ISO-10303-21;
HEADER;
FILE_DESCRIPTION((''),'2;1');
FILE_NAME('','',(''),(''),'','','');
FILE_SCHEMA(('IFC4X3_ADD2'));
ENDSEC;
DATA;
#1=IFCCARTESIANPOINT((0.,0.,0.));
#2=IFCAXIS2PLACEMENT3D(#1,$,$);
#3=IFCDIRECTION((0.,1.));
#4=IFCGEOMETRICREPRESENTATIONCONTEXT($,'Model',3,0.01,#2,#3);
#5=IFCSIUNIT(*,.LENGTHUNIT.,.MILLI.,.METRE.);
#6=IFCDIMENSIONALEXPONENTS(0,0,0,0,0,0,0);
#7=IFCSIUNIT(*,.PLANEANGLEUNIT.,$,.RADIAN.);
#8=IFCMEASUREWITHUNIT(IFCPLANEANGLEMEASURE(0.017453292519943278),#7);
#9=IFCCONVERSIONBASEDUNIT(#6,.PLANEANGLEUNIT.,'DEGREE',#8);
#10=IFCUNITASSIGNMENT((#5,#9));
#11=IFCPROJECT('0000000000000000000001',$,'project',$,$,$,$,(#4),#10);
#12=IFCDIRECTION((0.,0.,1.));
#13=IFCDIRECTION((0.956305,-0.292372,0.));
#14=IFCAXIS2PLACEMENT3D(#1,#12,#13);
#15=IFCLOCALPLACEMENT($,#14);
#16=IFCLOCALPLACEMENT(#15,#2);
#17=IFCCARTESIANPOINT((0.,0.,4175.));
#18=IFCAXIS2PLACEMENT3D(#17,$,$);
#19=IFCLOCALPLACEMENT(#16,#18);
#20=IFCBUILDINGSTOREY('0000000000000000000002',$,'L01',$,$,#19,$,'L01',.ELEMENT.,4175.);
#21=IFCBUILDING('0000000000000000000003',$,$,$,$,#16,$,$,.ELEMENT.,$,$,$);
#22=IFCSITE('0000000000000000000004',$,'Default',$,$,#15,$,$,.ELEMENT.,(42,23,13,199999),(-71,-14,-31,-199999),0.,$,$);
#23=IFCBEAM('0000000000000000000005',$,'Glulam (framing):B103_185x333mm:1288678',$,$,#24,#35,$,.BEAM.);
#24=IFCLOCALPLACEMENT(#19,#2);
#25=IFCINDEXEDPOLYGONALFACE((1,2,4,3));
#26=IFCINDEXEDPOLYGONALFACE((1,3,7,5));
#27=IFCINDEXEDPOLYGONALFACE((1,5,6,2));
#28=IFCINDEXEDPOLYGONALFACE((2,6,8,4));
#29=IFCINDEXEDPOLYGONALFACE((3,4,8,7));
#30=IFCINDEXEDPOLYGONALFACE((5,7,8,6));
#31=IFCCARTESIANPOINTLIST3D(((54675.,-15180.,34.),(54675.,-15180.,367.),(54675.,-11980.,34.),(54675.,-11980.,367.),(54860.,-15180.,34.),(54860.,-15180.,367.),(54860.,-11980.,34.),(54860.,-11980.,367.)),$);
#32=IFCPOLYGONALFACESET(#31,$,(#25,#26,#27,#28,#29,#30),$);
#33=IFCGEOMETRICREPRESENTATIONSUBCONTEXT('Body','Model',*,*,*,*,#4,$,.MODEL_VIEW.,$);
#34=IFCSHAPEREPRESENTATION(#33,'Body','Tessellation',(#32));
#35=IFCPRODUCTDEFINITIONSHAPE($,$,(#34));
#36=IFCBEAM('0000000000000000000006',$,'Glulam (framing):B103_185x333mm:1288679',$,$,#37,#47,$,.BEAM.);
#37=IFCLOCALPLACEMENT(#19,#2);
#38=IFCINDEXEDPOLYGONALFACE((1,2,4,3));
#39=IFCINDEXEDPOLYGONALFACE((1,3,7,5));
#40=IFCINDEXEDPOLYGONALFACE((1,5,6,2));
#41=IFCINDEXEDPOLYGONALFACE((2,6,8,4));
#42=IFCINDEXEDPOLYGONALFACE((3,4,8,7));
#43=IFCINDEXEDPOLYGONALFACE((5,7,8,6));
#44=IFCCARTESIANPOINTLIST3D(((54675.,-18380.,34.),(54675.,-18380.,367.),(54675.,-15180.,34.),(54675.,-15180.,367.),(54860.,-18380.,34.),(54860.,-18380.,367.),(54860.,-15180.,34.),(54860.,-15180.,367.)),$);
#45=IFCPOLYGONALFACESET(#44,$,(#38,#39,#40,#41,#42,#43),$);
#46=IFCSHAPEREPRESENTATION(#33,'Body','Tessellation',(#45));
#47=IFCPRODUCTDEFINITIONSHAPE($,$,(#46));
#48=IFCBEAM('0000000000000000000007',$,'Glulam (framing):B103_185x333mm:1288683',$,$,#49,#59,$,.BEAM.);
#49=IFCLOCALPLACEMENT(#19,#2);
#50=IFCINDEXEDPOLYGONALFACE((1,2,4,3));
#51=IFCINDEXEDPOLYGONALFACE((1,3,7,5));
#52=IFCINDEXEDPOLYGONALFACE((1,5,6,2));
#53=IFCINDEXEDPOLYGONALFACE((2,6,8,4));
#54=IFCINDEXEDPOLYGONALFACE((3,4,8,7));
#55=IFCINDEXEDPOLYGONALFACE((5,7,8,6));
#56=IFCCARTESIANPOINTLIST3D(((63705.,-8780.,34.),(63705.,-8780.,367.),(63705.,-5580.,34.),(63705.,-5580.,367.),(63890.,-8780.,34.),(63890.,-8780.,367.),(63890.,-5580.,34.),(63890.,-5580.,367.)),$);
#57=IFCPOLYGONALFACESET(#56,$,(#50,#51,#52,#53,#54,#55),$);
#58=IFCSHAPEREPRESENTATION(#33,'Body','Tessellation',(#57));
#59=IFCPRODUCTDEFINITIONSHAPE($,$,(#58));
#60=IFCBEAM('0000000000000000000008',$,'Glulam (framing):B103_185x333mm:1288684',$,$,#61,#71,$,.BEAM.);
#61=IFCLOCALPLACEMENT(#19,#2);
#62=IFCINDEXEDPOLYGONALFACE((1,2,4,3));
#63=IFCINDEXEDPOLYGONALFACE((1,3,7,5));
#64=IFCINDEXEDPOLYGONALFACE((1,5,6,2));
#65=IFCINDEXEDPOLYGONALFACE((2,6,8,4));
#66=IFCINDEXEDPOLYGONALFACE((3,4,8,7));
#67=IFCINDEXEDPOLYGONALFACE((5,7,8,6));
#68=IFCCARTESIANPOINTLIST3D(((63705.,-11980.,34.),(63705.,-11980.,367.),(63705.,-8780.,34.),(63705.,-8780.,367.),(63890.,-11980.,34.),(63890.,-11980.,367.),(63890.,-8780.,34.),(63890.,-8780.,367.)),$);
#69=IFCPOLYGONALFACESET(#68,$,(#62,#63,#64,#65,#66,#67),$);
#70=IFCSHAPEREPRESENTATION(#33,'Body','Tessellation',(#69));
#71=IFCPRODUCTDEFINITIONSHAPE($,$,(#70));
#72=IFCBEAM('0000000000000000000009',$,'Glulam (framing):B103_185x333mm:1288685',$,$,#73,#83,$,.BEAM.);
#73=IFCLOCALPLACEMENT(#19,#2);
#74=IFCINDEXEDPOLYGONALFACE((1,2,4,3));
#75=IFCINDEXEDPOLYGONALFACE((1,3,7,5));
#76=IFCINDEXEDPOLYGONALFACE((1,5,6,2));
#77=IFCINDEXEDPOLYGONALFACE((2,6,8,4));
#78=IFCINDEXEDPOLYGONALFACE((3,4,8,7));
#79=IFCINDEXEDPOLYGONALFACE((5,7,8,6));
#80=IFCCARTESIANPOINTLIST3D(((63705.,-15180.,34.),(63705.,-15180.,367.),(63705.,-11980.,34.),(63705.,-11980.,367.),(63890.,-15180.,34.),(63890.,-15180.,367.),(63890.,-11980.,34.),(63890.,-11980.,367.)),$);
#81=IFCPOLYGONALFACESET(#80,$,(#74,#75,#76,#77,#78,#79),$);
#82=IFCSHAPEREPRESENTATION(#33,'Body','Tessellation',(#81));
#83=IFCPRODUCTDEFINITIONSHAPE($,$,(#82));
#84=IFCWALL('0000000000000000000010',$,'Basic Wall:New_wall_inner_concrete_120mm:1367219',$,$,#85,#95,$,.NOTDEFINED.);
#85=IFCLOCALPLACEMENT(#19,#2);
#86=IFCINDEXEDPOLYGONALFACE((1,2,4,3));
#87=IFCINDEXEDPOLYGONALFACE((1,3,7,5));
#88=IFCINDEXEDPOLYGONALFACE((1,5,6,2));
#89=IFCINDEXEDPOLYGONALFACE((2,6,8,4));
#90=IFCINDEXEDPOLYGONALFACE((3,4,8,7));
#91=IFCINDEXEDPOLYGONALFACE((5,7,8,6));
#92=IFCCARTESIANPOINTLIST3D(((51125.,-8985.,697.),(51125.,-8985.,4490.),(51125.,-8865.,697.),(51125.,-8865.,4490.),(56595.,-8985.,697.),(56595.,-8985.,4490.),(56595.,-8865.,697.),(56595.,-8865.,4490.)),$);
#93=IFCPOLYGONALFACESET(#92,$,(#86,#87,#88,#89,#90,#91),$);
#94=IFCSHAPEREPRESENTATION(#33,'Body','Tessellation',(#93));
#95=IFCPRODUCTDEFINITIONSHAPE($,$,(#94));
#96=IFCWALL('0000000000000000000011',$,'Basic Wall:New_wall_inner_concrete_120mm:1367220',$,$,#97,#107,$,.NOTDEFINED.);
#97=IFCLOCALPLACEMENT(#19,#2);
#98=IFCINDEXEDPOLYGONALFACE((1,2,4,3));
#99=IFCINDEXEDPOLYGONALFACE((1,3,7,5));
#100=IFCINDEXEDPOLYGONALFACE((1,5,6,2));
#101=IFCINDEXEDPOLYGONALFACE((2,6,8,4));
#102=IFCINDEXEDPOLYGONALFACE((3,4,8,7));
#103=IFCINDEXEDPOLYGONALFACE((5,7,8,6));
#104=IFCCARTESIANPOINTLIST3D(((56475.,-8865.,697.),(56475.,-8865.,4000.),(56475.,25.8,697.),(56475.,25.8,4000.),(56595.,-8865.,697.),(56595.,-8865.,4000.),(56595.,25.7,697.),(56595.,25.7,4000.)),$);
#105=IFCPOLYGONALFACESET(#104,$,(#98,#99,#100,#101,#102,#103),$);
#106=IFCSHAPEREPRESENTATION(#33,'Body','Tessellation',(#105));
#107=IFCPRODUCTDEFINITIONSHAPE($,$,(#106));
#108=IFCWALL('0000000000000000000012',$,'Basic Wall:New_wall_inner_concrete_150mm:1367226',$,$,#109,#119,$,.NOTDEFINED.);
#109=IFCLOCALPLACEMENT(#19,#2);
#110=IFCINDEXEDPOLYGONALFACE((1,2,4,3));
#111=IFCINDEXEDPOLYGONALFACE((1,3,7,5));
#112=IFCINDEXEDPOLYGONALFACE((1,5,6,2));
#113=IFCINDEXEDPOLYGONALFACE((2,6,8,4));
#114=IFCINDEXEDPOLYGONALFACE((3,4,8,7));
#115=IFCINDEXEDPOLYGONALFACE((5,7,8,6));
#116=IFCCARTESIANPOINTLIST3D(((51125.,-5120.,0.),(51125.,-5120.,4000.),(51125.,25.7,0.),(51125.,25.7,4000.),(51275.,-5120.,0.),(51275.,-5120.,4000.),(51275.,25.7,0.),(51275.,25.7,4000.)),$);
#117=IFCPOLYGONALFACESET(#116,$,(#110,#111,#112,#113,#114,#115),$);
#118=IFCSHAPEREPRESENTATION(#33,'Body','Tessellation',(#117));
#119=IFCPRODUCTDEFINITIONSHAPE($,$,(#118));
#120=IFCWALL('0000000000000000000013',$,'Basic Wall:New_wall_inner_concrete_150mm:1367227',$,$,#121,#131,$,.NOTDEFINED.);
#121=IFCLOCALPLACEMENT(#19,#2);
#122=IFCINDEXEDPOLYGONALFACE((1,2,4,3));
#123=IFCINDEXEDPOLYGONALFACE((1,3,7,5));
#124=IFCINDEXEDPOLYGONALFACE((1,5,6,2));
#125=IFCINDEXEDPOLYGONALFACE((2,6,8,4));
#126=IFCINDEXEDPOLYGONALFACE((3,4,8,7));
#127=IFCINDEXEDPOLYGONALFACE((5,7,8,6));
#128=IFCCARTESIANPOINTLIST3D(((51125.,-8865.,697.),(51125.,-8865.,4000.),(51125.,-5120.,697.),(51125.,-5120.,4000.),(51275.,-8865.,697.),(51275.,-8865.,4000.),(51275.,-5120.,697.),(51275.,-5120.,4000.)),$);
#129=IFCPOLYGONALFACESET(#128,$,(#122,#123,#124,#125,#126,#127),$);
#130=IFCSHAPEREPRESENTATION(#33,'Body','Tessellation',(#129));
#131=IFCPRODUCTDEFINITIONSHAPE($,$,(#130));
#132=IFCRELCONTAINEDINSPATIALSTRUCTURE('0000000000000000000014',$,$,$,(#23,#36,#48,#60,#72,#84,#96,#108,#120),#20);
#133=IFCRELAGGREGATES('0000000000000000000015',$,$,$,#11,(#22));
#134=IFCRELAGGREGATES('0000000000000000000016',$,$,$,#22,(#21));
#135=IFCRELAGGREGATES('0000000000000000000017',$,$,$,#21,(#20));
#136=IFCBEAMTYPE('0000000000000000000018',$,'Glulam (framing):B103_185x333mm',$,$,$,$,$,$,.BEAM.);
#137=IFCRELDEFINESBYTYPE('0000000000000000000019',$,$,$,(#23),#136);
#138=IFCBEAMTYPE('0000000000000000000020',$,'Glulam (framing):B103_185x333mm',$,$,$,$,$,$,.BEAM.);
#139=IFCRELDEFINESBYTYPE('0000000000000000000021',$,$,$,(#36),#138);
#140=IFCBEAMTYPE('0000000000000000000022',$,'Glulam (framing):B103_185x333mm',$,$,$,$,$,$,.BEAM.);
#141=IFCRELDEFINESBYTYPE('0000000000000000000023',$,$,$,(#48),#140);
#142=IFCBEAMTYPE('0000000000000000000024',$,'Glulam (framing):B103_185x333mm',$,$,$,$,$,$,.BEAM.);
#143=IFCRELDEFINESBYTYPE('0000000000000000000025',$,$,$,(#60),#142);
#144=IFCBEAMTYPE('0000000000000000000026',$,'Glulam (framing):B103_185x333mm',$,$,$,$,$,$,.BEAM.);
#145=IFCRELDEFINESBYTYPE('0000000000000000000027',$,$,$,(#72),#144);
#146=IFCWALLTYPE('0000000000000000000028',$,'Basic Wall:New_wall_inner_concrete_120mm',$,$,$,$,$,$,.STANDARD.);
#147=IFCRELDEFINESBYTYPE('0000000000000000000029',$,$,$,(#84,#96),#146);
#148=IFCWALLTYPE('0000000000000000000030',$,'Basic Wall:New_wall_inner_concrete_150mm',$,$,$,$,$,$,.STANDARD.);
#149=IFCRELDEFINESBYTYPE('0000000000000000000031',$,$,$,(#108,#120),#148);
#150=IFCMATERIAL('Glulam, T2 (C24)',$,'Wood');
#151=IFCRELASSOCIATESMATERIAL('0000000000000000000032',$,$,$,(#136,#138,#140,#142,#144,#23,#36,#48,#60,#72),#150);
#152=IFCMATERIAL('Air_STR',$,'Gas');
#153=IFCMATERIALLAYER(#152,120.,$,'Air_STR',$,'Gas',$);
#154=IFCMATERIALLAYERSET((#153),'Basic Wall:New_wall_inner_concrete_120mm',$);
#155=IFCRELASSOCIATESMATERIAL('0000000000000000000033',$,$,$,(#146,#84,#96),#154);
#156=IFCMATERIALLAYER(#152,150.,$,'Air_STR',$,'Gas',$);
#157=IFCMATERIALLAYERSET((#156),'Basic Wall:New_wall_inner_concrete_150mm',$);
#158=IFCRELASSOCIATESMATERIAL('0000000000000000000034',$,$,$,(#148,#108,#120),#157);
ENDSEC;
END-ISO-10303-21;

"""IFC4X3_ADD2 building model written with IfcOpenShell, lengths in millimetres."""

from ifc_helpers import new_model, entity, si_unit, converted_unit, direction, frame, frame_2d, origin, origin_2d_with_axis, place, context, subcontext, project, spatial, rectangle, extrude, source, transform, mapped, material, layer, layer_set, material_profile, profile_set, profile_usage, type_object, type_shapes, element, save


model = new_model("IFC4X3_ADD2")

# Units and contexts
model_context = context("Model", 3, precision=0.01, world=origin(), true_north=direction((0.0, 1.0)))
body_context = subcontext(model_context, "Body", "Model", "MODEL_VIEW")
ifc_project = project(units=[si_unit("LENGTHUNIT", "METRE", prefix="MILLI"), converted_unit("PLANEANGLEUNIT", "DEGREE", entity("IfcPlaneAngleMeasure", 0.017453292519943278), si_unit("PLANEANGLEUNIT", "RADIAN"), dimensions=[0, 0, 0, 0, 0, 0, 0])], contexts=[model_context])

# Site, building, storey
site_placement = place(None, frame((0.0, 0.0, 0.0), z_axis=(0.0, 0.0, 1.0), x_axis=(0.956305, -0.292372, 0.0)))
site = spatial("IfcSite", under=ifc_project, at=site_placement, Name="Default", CompositionType="ELEMENT", RefLatitude=(42, 23, 13, 199999), RefLongitude=(-71, -14, -31, -199999), RefElevation=0.0)
building_placement = place(site_placement, origin())
building = spatial("IfcBuilding", under=site, at=building_placement, CompositionType="ELEMENT")
storey_placement = place(building_placement, frame((0.0, 0.0, 4175.0)))
storey = spatial("IfcBuildingStorey", under=building, at=storey_placement, Name="L01", LongName="L01", CompositionType="ELEMENT", Elevation=4175.0)

# Beams
ifc_material_1 = material(Name="Glulam, T2 (C24)", Category="Wood")
ifc_material_profile_1 = material_profile(ifc_material_1, rectangle(XDim=3200.0, YDim=185.0, at=origin_2d_with_axis()), Name="B103_185x333mm")
ifc_profile_set_1 = profile_set([ifc_material_profile_1], Name="B103_185x333mm")
ifc_profile_usage_1 = profile_usage(ifc_profile_set_1, cardinal=8)
beam_type_1 = type_object("IfcBeamType", Name="Glulam (framing):B103_185x333mm", PredefinedType="BEAM", material=ifc_profile_set_1)
shared_shape_1 = source(origin(), body_context, "Body", "SweptSolid", [
    extrude(rectangle(XDim=3200.0, YDim=185.0, at=origin_2d_with_axis()), frame((0.0, 0.0, -166.5), z_axis=(0.0, 0.0, 1.0), x_axis=(-1.0, 0.0, 0.0)), (0.0, 0.0, 1.0), 333.0),
])
type_shapes(beam_type_1, [shared_shape_1])
beam_1_placement = place(storey_placement, frame((54767.5, -13580.0, 200.5), z_axis=(0.0, 0.0, 1.0), x_axis=(0.0, -1.0, 0.0)))
element("IfcBeam", 1, at=beam_1_placement, inside=storey, type_object=beam_type_1, material=ifc_profile_usage_1, Name="Glulam (framing):B103_185x333mm:1288678", PredefinedType="BEAM", context=body_context, shape_type="MappedRepresentation", body=[
    mapped(shared_shape_1, transform((0.0, 0.0, 0.0), scale=1.0)),
])
beam_type_2 = type_object("IfcBeamType", Name="Glulam (framing):B103_185x333mm", PredefinedType="BEAM", material=ifc_profile_set_1)
shared_shape_2 = source(origin(), body_context, "Body", "SweptSolid", [
    extrude(rectangle(XDim=3200.0, YDim=185.0, at=origin_2d_with_axis()), frame((0.0, 0.0, -166.5), z_axis=(0.0, 0.0, 1.0), x_axis=(-1.0, 0.0, 0.0)), (0.0, 0.0, 1.0), 333.0),
])
type_shapes(beam_type_2, [shared_shape_2])
beam_2_placement = place(storey_placement, frame((54767.5, -16780.0, 200.5), z_axis=(0.0, 0.0, 1.0), x_axis=(0.0, -1.0, 0.0)))
element("IfcBeam", 2, at=beam_2_placement, inside=storey, type_object=beam_type_2, material=ifc_profile_usage_1, Name="Glulam (framing):B103_185x333mm:1288679", PredefinedType="BEAM", context=body_context, shape_type="MappedRepresentation", body=[
    mapped(shared_shape_2, transform((0.0, 0.0, 0.0), scale=1.0)),
])
beam_type_3 = type_object("IfcBeamType", Name="Glulam (framing):B103_185x333mm", PredefinedType="BEAM", material=ifc_profile_set_1)
shared_shape_3 = source(origin(), body_context, "Body", "SweptSolid", [
    extrude(rectangle(XDim=185.0, YDim=3200.0, at=origin_2d_with_axis()), frame((0.0, 0.0, -166.5), z_axis=(0.0, 0.0, 1.0), x_axis=(0.0, 1.0, 0.0)), (0.0, 0.0, 1.0), 333.0),
])
type_shapes(beam_type_3, [shared_shape_3])
beam_3_placement = place(storey_placement, frame((63797.5, -7180.0, 200.5), z_axis=(0.0, 0.0, 1.0), x_axis=(0.0, -1.0, 0.0)))
element("IfcBeam", 3, at=beam_3_placement, inside=storey, type_object=beam_type_3, material=ifc_profile_usage_1, Name="Glulam (framing):B103_185x333mm:1288683", PredefinedType="BEAM", context=body_context, shape_type="MappedRepresentation", body=[
    mapped(shared_shape_3, transform((0.0, 0.0, 0.0), scale=1.0)),
])
beam_type_4 = type_object("IfcBeamType", Name="Glulam (framing):B103_185x333mm", PredefinedType="BEAM", material=ifc_profile_set_1)
shared_shape_4 = source(origin(), body_context, "Body", "SweptSolid", [
    extrude(rectangle(XDim=185.0, YDim=3200.0, at=origin_2d_with_axis()), frame((0.0, 0.0, -166.5), z_axis=(0.0, 0.0, 1.0), x_axis=(0.0, 1.0, 0.0)), (0.0, 0.0, 1.0), 333.0),
])
type_shapes(beam_type_4, [shared_shape_4])
beam_4_placement = place(storey_placement, frame((63797.5, -10380.0, 200.5), z_axis=(0.0, 0.0, 1.0), x_axis=(0.0, -1.0, 0.0)))
element("IfcBeam", 4, at=beam_4_placement, inside=storey, type_object=beam_type_4, material=ifc_profile_usage_1, Name="Glulam (framing):B103_185x333mm:1288684", PredefinedType="BEAM", context=body_context, shape_type="MappedRepresentation", body=[
    mapped(shared_shape_4, transform((0.0, 0.0, 0.0), scale=1.0)),
])
beam_type_5 = type_object("IfcBeamType", Name="Glulam (framing):B103_185x333mm", PredefinedType="BEAM", material=ifc_profile_set_1)
shared_shape_5 = source(origin(), body_context, "Body", "SweptSolid", [
    extrude(rectangle(XDim=185.0, YDim=3200.0, at=origin_2d_with_axis()), frame((0.0, 0.0, -166.5), z_axis=(0.0, 0.0, 1.0), x_axis=(0.0, 1.0, 0.0)), (0.0, 0.0, 1.0), 333.0),
])
type_shapes(beam_type_5, [shared_shape_5])
beam_5_placement = place(storey_placement, frame((63797.5, -13580.0, 200.5), z_axis=(0.0, 0.0, 1.0), x_axis=(0.0, -1.0, 0.0)))
element("IfcBeam", 5, at=beam_5_placement, inside=storey, type_object=beam_type_5, material=ifc_profile_usage_1, Name="Glulam (framing):B103_185x333mm:1288685", PredefinedType="BEAM", context=body_context, shape_type="MappedRepresentation", body=[
    mapped(shared_shape_5, transform((0.0, 0.0, 0.0), scale=1.0)),
])

# Walls
ifc_material_2 = material(Name="Air_STR", Category="Gas")
ifc_layer_1 = layer(ifc_material_2, 120.0, Name="Air_STR", Category="Gas")
ifc_layer_set_1 = layer_set([ifc_layer_1], Name="Basic Wall:New_wall_inner_concrete_120mm")
wall_type_1 = type_object("IfcWallType", Name="Basic Wall:New_wall_inner_concrete_120mm", PredefinedType="STANDARD", material=ifc_layer_set_1)
wall_1_placement = place(storey_placement, frame((51125.0, -8925.0, 697.0)))
element("IfcWall", 6, at=wall_1_placement, inside=storey, type_object=wall_type_1, material=ifc_layer_set_1, Name="Basic Wall:New_wall_inner_concrete_120mm:1367219", PredefinedType="NOTDEFINED", context=body_context, shape_type="SweptSolid", body=[
    extrude(rectangle(XDim=5470.0, YDim=120.0, at=frame_2d((2735.0, 0.0), x_axis=(-1.0, 0.0))), origin(), (0.0, 0.0, 1.0), 3793.0),
])
wall_2_placement = place(storey_placement, frame((56535.0, -8865.0, 697.0), z_axis=(0.0, 0.0, 1.0), x_axis=(0.0, 1.0, 0.0)))
element("IfcWall", 7, at=wall_2_placement, inside=storey, type_object=wall_type_1, material=ifc_layer_set_1, Name="Basic Wall:New_wall_inner_concrete_120mm:1367220", PredefinedType="NOTDEFINED", context=body_context, shape_type="SweptSolid", body=[
    extrude(rectangle(XDim=8890.8, YDim=120.0, at=frame_2d((4445.4, 0.0), x_axis=(-1.0, 0.0))), origin(), (0.0, 0.0, 1.0), 3303.0),
])
ifc_layer_2 = layer(ifc_material_2, 150.0, Name="Air_STR", Category="Gas")
ifc_layer_set_2 = layer_set([ifc_layer_2], Name="Basic Wall:New_wall_inner_concrete_150mm")
wall_type_2 = type_object("IfcWallType", Name="Basic Wall:New_wall_inner_concrete_150mm", PredefinedType="STANDARD", material=ifc_layer_set_2)
wall_3_placement = place(storey_placement, frame((51200.0, -5120.0, 0.0), z_axis=(0.0, 0.0, 1.0), x_axis=(0.0, 1.0, 0.0)))
element("IfcWall", 8, at=wall_3_placement, inside=storey, type_object=wall_type_2, material=ifc_layer_set_2, Name="Basic Wall:New_wall_inner_concrete_150mm:1367226", PredefinedType="NOTDEFINED", context=body_context, shape_type="SweptSolid", body=[
    extrude(rectangle(XDim=5145.7, YDim=150.0, at=frame_2d((2572.9, 0.0), x_axis=(-1.0, 0.0))), origin(), (0.0, 0.0, 1.0), 4000.0),
])
wall_4_placement = place(storey_placement, frame((51200.0, -8865.0, 697.0), z_axis=(0.0, 0.0, 1.0), x_axis=(0.0, 1.0, 0.0)))
element("IfcWall", 9, at=wall_4_placement, inside=storey, type_object=wall_type_2, material=ifc_layer_set_2, Name="Basic Wall:New_wall_inner_concrete_150mm:1367227", PredefinedType="NOTDEFINED", context=body_context, shape_type="SweptSolid", body=[
    extrude(rectangle(XDim=3745.0, YDim=150.0, at=frame_2d((1872.5, 0.0), x_axis=(-1.0, 0.0))), origin(), (0.0, 0.0, 1.0), 3303.0),
])

save(model, "model.ifc")
